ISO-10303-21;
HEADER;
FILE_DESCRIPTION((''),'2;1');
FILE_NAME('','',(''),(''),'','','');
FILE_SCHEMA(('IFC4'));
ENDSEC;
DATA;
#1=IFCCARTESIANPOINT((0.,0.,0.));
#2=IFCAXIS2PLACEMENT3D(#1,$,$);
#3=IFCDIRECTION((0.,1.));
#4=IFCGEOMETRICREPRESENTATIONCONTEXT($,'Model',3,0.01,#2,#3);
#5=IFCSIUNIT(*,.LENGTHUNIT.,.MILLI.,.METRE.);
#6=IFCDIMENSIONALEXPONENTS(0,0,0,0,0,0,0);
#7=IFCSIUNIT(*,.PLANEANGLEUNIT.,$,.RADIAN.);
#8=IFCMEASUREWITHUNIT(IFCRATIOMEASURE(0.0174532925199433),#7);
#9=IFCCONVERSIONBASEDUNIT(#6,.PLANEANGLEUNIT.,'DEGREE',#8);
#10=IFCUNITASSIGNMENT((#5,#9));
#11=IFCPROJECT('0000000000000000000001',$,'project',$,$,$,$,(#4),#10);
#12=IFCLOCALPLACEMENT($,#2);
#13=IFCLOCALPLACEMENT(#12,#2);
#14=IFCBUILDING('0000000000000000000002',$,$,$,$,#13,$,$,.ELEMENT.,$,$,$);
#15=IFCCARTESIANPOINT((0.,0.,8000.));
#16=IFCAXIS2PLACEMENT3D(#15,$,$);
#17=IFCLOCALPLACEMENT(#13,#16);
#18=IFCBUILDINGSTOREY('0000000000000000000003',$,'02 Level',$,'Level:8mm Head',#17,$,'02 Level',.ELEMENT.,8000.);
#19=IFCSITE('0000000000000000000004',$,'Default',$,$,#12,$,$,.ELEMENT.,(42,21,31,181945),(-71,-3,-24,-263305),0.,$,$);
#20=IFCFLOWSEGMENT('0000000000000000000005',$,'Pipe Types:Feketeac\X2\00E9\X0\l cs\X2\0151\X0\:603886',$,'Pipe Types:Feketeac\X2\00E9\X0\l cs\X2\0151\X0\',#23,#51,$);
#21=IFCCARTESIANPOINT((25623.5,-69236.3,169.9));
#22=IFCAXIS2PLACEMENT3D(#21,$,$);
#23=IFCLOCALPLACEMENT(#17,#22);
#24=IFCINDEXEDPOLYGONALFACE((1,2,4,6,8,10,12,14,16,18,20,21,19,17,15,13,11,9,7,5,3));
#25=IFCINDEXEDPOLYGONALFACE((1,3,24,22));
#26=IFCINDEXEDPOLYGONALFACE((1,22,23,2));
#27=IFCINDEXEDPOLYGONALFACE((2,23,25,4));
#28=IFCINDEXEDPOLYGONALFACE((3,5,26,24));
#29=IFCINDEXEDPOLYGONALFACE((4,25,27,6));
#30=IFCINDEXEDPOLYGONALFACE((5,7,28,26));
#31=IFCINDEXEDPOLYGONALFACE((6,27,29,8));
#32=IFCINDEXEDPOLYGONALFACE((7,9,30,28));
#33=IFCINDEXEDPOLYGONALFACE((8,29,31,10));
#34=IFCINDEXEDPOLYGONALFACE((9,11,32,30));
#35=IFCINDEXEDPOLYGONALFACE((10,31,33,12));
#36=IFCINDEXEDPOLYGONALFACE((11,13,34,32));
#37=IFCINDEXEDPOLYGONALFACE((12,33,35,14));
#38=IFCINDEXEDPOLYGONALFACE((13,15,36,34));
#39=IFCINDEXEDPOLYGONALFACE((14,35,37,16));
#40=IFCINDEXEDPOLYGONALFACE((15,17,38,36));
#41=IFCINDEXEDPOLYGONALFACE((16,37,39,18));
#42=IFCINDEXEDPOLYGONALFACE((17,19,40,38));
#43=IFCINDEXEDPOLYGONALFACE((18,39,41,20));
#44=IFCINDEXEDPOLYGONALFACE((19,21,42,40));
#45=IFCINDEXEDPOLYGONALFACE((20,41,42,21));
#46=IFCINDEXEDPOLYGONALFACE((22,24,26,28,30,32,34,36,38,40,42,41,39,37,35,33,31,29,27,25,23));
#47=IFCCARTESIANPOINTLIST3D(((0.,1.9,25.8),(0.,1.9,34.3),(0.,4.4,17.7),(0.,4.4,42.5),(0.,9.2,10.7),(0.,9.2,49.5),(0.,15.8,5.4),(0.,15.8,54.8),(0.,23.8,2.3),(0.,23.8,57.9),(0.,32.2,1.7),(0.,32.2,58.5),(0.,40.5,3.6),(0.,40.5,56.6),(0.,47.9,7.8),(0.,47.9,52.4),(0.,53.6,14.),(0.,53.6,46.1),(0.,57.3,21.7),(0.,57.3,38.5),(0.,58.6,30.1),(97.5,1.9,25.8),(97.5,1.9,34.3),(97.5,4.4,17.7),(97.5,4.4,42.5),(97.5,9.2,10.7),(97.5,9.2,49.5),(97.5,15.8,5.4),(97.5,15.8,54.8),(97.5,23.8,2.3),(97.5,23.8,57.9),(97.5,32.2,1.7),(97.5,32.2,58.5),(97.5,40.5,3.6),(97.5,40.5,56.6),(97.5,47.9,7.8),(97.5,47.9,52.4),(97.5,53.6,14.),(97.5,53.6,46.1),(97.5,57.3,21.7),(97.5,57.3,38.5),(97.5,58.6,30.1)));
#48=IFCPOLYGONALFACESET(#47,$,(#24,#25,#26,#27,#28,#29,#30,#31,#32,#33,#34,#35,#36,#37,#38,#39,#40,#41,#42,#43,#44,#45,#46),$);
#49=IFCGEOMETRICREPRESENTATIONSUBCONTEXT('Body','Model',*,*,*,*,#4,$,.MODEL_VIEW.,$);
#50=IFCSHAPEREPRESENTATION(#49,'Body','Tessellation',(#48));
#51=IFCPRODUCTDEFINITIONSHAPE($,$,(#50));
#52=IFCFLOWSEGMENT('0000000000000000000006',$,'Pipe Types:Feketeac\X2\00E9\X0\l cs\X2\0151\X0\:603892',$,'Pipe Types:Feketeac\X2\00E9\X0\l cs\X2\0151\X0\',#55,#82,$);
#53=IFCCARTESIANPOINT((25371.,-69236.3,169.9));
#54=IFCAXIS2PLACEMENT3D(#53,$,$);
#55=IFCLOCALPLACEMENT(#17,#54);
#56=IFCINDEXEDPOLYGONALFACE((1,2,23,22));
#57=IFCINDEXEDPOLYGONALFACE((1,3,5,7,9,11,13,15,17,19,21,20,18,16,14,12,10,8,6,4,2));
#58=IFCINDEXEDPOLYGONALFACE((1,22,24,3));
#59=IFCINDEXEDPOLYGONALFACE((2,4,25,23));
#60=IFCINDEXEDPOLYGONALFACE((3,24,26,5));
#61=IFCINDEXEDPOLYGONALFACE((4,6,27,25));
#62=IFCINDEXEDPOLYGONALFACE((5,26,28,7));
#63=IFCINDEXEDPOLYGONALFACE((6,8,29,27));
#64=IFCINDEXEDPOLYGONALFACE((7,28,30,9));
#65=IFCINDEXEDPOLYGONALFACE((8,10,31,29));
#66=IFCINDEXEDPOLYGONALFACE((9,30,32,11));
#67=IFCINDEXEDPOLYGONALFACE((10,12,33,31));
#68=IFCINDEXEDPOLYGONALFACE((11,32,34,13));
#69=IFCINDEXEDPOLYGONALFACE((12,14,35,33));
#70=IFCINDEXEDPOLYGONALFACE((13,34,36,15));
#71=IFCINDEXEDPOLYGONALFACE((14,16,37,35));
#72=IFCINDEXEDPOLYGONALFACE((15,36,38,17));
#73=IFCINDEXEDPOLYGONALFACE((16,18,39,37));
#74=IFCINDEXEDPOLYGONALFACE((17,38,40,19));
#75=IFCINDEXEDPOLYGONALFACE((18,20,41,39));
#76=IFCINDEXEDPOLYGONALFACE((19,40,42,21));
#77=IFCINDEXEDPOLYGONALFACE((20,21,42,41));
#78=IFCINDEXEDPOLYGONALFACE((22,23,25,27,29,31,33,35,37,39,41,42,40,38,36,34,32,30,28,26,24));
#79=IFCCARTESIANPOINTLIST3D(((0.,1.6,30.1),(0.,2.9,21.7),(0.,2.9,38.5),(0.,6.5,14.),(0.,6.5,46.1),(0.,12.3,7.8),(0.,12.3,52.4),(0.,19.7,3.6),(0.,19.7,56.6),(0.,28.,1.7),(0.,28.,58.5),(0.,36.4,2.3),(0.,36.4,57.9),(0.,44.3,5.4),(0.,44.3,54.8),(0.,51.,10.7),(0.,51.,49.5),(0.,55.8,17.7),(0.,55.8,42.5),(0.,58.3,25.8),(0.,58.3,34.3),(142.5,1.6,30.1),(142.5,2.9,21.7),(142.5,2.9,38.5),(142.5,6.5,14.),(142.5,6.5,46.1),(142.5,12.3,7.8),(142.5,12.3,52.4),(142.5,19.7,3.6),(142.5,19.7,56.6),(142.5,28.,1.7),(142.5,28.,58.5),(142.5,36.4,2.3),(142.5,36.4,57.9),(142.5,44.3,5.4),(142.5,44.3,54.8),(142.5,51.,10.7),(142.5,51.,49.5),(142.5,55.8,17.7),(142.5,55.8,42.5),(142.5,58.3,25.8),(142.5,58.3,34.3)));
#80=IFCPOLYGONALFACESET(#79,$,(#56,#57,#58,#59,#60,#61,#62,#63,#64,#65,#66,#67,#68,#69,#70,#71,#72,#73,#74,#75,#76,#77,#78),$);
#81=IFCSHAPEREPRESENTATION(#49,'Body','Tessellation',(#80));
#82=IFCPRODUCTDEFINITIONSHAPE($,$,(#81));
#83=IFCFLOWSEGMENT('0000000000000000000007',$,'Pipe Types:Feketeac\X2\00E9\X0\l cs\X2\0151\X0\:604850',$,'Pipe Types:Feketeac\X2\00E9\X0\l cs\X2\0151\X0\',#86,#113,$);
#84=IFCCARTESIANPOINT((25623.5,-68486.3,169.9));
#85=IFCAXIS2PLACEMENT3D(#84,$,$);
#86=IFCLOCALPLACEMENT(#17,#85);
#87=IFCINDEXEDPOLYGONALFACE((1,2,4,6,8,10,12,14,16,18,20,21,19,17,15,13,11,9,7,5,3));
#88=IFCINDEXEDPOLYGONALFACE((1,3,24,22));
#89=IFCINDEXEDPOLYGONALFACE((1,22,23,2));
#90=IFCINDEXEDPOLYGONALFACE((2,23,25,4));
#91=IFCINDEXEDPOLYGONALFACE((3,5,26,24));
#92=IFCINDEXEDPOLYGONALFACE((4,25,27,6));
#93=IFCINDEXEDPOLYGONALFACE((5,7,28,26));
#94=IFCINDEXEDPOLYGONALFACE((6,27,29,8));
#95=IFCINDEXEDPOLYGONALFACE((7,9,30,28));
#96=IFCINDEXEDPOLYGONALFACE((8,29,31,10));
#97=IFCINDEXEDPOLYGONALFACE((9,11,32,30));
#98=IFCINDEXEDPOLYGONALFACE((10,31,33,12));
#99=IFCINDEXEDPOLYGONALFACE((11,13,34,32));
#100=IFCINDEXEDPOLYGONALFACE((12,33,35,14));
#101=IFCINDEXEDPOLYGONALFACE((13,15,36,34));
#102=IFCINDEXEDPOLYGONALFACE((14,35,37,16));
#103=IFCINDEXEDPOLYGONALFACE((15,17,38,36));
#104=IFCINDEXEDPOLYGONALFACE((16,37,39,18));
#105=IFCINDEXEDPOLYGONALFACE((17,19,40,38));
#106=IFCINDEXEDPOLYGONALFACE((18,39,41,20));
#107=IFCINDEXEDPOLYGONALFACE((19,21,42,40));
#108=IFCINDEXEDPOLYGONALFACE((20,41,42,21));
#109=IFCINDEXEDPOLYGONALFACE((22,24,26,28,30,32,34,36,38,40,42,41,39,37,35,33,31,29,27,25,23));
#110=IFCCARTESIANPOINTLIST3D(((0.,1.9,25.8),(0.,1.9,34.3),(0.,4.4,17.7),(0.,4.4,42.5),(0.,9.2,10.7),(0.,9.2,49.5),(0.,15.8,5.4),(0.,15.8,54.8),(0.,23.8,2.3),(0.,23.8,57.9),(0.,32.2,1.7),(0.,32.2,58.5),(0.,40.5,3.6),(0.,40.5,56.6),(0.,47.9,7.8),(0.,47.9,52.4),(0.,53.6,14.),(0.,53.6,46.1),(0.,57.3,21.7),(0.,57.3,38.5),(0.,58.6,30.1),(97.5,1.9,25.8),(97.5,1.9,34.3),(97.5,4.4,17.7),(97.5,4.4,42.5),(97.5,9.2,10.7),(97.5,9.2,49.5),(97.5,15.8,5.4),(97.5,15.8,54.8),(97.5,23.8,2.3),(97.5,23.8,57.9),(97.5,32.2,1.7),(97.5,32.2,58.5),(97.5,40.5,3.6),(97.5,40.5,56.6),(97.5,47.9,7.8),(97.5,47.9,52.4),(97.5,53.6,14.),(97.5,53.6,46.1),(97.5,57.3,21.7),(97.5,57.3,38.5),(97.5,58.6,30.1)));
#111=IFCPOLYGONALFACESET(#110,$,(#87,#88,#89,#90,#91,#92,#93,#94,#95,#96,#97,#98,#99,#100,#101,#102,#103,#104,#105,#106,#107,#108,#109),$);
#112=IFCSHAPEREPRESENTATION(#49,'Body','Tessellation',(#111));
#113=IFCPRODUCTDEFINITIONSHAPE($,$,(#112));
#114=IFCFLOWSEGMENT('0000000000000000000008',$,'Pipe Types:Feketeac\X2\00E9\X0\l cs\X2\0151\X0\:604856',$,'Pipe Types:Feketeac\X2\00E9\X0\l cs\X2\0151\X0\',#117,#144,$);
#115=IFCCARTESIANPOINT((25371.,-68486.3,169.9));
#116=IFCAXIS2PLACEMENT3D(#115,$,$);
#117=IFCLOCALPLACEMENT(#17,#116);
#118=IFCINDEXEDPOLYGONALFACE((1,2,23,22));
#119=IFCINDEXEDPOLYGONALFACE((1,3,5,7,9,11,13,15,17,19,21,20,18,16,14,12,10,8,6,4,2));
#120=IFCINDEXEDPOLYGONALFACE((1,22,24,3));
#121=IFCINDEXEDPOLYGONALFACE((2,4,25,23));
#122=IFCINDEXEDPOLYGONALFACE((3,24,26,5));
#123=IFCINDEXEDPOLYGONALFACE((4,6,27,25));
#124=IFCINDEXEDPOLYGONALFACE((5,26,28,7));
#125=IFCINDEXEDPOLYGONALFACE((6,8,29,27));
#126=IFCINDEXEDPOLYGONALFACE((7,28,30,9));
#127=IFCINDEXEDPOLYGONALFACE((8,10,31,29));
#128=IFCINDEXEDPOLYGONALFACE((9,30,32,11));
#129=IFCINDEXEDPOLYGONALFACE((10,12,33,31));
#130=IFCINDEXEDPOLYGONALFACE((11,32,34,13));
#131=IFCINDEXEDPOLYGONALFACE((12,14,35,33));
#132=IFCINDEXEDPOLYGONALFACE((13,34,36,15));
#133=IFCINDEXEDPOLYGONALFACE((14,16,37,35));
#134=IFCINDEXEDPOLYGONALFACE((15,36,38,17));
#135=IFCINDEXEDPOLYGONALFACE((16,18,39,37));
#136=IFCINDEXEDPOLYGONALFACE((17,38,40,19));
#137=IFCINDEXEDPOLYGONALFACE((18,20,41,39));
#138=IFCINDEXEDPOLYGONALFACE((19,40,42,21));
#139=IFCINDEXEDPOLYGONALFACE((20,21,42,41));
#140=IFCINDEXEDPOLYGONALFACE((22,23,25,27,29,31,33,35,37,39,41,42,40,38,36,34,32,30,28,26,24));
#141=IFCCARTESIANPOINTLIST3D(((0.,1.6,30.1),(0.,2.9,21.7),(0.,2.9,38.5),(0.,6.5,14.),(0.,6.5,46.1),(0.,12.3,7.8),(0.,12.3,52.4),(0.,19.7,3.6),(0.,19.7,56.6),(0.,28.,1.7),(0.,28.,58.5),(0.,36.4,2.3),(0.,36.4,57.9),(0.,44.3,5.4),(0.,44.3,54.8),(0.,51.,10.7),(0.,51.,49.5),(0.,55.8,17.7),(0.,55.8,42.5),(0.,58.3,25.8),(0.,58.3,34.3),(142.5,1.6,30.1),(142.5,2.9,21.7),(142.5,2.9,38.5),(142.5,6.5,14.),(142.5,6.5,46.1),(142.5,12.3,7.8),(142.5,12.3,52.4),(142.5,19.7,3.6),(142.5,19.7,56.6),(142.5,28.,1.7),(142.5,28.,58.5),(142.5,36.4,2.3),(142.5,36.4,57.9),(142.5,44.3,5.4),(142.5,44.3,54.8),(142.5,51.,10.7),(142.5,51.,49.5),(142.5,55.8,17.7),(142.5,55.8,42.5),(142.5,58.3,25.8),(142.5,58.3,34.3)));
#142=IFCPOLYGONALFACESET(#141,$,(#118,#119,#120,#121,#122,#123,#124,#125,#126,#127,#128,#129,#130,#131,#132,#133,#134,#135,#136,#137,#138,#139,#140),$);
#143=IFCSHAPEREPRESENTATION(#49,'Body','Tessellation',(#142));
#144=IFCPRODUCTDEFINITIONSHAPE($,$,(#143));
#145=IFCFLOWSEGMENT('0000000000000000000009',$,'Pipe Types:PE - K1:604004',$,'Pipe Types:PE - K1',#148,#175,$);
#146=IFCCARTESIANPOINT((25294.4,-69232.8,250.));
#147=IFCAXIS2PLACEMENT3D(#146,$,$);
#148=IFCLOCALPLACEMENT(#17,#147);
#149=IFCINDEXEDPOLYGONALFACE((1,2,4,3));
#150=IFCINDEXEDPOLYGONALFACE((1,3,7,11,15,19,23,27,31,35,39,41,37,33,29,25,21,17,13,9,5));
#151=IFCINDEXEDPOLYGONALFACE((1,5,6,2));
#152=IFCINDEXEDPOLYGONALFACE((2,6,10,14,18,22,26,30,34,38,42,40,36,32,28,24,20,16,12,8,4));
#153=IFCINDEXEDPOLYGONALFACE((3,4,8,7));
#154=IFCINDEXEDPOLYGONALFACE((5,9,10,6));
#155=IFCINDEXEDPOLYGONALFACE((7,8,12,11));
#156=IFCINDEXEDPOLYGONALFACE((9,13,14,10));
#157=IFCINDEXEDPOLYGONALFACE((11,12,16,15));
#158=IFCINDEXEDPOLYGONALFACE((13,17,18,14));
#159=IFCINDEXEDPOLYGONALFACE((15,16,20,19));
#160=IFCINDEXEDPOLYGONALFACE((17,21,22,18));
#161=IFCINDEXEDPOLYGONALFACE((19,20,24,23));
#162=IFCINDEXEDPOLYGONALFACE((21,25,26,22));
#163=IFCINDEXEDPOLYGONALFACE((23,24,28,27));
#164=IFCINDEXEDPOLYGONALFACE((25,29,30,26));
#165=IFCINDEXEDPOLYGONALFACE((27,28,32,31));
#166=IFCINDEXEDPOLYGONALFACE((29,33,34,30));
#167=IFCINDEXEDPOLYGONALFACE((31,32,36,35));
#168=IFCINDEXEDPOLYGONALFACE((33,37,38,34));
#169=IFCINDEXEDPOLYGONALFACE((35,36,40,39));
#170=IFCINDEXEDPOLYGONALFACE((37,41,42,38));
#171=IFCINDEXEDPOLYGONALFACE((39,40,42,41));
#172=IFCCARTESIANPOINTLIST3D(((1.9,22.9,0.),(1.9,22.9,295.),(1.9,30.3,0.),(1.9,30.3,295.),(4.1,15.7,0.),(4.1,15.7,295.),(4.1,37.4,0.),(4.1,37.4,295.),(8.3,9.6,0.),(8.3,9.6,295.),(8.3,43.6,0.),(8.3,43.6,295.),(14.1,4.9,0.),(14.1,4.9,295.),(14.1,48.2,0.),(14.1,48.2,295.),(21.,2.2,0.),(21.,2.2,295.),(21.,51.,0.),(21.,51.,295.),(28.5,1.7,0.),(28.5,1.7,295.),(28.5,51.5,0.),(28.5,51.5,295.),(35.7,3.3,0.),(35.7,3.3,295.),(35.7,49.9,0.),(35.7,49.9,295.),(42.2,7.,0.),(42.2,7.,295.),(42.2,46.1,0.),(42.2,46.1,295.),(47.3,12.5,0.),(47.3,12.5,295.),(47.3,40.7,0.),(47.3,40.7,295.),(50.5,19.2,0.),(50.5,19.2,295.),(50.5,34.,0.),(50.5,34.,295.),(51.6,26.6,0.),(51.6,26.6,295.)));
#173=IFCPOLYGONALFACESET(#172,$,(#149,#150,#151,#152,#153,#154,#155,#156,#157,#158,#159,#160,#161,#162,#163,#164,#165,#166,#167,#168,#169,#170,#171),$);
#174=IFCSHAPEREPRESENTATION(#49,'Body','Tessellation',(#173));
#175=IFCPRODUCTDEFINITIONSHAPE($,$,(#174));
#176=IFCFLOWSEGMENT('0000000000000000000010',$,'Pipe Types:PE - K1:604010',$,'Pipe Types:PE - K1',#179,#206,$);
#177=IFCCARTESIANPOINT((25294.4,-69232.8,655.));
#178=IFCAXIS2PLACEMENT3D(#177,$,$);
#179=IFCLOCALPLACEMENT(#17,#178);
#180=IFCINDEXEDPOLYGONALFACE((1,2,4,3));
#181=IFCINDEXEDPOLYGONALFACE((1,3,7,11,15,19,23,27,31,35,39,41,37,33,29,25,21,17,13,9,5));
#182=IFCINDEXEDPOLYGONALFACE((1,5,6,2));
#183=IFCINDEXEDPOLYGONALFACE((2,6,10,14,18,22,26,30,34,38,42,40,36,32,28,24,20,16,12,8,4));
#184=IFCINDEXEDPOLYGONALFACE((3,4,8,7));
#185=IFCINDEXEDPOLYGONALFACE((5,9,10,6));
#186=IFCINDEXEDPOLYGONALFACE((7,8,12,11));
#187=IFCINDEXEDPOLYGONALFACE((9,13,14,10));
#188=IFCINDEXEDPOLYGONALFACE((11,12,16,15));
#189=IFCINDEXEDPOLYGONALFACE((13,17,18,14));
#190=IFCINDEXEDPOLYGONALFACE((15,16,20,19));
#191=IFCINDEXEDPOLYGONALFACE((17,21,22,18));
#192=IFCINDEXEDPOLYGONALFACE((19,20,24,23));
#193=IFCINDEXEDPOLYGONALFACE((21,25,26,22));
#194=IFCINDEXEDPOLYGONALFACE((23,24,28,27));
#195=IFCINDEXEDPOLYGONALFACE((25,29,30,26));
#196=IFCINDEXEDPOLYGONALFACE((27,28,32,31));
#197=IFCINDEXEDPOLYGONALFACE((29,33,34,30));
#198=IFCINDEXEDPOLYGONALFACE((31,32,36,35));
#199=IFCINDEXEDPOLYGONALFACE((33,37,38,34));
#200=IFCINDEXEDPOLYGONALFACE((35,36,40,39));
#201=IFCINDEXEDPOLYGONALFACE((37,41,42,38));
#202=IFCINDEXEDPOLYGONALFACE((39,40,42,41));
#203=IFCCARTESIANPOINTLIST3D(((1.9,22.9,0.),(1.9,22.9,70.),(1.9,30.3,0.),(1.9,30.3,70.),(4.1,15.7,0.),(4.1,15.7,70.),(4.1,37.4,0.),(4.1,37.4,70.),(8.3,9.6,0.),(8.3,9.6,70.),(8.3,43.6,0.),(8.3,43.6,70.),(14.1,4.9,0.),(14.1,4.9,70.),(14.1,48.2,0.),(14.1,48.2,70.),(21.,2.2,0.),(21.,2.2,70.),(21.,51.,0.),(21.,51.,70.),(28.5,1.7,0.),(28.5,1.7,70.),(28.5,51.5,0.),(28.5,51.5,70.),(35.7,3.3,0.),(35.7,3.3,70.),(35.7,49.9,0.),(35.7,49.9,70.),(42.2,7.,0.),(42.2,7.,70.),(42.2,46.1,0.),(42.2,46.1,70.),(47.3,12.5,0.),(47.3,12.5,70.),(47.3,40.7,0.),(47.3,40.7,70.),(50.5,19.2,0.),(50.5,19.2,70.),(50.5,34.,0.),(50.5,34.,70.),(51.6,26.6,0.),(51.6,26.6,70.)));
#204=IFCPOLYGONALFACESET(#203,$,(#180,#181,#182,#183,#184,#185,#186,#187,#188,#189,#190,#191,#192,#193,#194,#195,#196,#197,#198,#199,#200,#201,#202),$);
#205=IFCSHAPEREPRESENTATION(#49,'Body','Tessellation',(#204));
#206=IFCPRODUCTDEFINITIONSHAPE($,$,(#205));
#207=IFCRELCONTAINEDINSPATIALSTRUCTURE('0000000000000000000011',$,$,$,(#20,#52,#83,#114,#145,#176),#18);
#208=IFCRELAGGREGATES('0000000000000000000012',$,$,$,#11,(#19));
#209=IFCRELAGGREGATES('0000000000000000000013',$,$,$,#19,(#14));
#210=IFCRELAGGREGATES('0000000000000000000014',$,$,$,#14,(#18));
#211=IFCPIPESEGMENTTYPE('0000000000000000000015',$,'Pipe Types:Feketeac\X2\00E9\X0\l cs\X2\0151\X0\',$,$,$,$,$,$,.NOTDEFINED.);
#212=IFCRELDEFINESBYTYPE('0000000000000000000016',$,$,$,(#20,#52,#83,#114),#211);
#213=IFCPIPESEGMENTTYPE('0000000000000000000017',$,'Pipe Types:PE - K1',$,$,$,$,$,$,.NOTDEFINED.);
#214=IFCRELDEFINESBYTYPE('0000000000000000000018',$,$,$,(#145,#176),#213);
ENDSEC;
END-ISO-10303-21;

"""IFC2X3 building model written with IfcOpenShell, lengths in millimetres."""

from ifc_helpers import new_model, entity, si_unit, converted_unit, direction, frame, frame_2d, origin, origin_2d_with_axis, place, context, subcontext, project, spatial, circle, extrude, type_object, element, save


model = new_model("IFC2X3")

# Units and contexts
model_context = context("Model", 3, precision=0.01, world=origin(), true_north=direction((0.0, 1.0)))
body_context = subcontext(model_context, "Body", "Model", "MODEL_VIEW")
ifc_project = project(units=[si_unit("LENGTHUNIT", "METRE", prefix="MILLI"), converted_unit("PLANEANGLEUNIT", "DEGREE", entity("IfcRatioMeasure", 0.0174532925199433), si_unit("PLANEANGLEUNIT", "RADIAN"), dimensions=[0, 0, 0, 0, 0, 0, 0])], contexts=[model_context])

# Site, building, storey
site_placement = place(None, origin())
site = spatial("IfcSite", under=ifc_project, at=site_placement, Name="Default", CompositionType="ELEMENT", RefLatitude=(42, 21, 31, 181945), RefLongitude=(-71, -3, -24, -263305), RefElevation=0.0)
building_placement = place(site_placement, origin())
building = spatial("IfcBuilding", under=site, at=building_placement, CompositionType="ELEMENT")
storey_placement = place(building_placement, frame((0.0, 0.0, 8000.0)))
storey = spatial("IfcBuildingStorey", under=building, at=storey_placement, Name="02 Level", ObjectType="Level:8mm Head", LongName="02 Level", CompositionType="ELEMENT", Elevation=8000.0)

# Flow segments
pipe_segment_type_1 = type_object("IfcPipeSegmentType", Name="Pipe Types:Feketeacél cső", PredefinedType="NOTDEFINED")
flow_segment_1_placement = place(storey_placement, frame((25623.5, -69236.3, 169.9)))
element("IfcFlowSegment", 1, at=flow_segment_1_placement, inside=storey, type_object=pipe_segment_type_1, Name="Pipe Types:Feketeacél cső:603886", ObjectType="Pipe Types:Feketeacél cső", context=body_context, shape_type="SweptSolid", body=[
    extrude(circle(Radius=28.5, at=frame_2d((0.0, 0.0), x_axis=(1.0, 0.0))), frame((0.0, 30.1, 30.1), z_axis=(1.0, 0.0, 0.0), x_axis=(0.0, 1.0, 0.0)), (0.0, 0.0, 1.0), 97.5),
])
flow_segment_2_placement = place(storey_placement, frame((25371.0, -69236.3, 169.9)))
element("IfcFlowSegment", 2, at=flow_segment_2_placement, inside=storey, type_object=pipe_segment_type_1, Name="Pipe Types:Feketeacél cső:603892", ObjectType="Pipe Types:Feketeacél cső", context=body_context, shape_type="SweptSolid", body=[
    extrude(circle(Radius=28.5, at=origin_2d_with_axis()), frame((0.0, 30.1, 30.1), z_axis=(1.0, 0.0, 0.0), x_axis=(0.0, -1.0, 0.0)), (0.0, 0.0, 1.0), 142.5),
])
flow_segment_3_placement = place(storey_placement, frame((25623.5, -68486.3, 169.9)))
element("IfcFlowSegment", 3, at=flow_segment_3_placement, inside=storey, type_object=pipe_segment_type_1, Name="Pipe Types:Feketeacél cső:604850", ObjectType="Pipe Types:Feketeacél cső", context=body_context, shape_type="SweptSolid", body=[
    extrude(circle(Radius=28.5, at=frame_2d((0.0, 0.0), x_axis=(1.0, 0.0))), frame((0.0, 30.1, 30.1), z_axis=(1.0, 0.0, 0.0), x_axis=(0.0, 1.0, 0.0)), (0.0, 0.0, 1.0), 97.5),
])
flow_segment_4_placement = place(storey_placement, frame((25371.0, -68486.3, 169.9)))
element("IfcFlowSegment", 4, at=flow_segment_4_placement, inside=storey, type_object=pipe_segment_type_1, Name="Pipe Types:Feketeacél cső:604856", ObjectType="Pipe Types:Feketeacél cső", context=body_context, shape_type="SweptSolid", body=[
    extrude(circle(Radius=28.5, at=origin_2d_with_axis()), frame((0.0, 30.1, 30.1), z_axis=(1.0, 0.0, 0.0), x_axis=(0.0, -1.0, 0.0)), (0.0, 0.0, 1.0), 142.5),
])
pipe_segment_type_2 = type_object("IfcPipeSegmentType", Name="Pipe Types:PE - K1", PredefinedType="NOTDEFINED")
flow_segment_5_placement = place(storey_placement, frame((25294.4, -69232.8, 250.0)))
element("IfcFlowSegment", 5, at=flow_segment_5_placement, inside=storey, type_object=pipe_segment_type_2, Name="Pipe Types:PE - K1:604004", ObjectType="Pipe Types:PE - K1", context=body_context, shape_type="SweptSolid", body=[
    extrude(circle(Radius=25.0, at=frame_2d((0.0, 0.0), x_axis=(1.0, 0.0))), frame((26.6, 26.6, 0.0)), (0.0, 0.0, 1.0), 295.0),
])
flow_segment_6_placement = place(storey_placement, frame((25294.4, -69232.8, 655.0)))
element("IfcFlowSegment", 6, at=flow_segment_6_placement, inside=storey, type_object=pipe_segment_type_2, Name="Pipe Types:PE - K1:604010", ObjectType="Pipe Types:PE - K1", context=body_context, shape_type="SweptSolid", body=[
    extrude(circle(Radius=25.0, at=origin_2d_with_axis()), frame((26.6, 26.6, 0.0)), (0.0, 0.0, 1.0), 70.0),
])

save(model, "model.ifc")
